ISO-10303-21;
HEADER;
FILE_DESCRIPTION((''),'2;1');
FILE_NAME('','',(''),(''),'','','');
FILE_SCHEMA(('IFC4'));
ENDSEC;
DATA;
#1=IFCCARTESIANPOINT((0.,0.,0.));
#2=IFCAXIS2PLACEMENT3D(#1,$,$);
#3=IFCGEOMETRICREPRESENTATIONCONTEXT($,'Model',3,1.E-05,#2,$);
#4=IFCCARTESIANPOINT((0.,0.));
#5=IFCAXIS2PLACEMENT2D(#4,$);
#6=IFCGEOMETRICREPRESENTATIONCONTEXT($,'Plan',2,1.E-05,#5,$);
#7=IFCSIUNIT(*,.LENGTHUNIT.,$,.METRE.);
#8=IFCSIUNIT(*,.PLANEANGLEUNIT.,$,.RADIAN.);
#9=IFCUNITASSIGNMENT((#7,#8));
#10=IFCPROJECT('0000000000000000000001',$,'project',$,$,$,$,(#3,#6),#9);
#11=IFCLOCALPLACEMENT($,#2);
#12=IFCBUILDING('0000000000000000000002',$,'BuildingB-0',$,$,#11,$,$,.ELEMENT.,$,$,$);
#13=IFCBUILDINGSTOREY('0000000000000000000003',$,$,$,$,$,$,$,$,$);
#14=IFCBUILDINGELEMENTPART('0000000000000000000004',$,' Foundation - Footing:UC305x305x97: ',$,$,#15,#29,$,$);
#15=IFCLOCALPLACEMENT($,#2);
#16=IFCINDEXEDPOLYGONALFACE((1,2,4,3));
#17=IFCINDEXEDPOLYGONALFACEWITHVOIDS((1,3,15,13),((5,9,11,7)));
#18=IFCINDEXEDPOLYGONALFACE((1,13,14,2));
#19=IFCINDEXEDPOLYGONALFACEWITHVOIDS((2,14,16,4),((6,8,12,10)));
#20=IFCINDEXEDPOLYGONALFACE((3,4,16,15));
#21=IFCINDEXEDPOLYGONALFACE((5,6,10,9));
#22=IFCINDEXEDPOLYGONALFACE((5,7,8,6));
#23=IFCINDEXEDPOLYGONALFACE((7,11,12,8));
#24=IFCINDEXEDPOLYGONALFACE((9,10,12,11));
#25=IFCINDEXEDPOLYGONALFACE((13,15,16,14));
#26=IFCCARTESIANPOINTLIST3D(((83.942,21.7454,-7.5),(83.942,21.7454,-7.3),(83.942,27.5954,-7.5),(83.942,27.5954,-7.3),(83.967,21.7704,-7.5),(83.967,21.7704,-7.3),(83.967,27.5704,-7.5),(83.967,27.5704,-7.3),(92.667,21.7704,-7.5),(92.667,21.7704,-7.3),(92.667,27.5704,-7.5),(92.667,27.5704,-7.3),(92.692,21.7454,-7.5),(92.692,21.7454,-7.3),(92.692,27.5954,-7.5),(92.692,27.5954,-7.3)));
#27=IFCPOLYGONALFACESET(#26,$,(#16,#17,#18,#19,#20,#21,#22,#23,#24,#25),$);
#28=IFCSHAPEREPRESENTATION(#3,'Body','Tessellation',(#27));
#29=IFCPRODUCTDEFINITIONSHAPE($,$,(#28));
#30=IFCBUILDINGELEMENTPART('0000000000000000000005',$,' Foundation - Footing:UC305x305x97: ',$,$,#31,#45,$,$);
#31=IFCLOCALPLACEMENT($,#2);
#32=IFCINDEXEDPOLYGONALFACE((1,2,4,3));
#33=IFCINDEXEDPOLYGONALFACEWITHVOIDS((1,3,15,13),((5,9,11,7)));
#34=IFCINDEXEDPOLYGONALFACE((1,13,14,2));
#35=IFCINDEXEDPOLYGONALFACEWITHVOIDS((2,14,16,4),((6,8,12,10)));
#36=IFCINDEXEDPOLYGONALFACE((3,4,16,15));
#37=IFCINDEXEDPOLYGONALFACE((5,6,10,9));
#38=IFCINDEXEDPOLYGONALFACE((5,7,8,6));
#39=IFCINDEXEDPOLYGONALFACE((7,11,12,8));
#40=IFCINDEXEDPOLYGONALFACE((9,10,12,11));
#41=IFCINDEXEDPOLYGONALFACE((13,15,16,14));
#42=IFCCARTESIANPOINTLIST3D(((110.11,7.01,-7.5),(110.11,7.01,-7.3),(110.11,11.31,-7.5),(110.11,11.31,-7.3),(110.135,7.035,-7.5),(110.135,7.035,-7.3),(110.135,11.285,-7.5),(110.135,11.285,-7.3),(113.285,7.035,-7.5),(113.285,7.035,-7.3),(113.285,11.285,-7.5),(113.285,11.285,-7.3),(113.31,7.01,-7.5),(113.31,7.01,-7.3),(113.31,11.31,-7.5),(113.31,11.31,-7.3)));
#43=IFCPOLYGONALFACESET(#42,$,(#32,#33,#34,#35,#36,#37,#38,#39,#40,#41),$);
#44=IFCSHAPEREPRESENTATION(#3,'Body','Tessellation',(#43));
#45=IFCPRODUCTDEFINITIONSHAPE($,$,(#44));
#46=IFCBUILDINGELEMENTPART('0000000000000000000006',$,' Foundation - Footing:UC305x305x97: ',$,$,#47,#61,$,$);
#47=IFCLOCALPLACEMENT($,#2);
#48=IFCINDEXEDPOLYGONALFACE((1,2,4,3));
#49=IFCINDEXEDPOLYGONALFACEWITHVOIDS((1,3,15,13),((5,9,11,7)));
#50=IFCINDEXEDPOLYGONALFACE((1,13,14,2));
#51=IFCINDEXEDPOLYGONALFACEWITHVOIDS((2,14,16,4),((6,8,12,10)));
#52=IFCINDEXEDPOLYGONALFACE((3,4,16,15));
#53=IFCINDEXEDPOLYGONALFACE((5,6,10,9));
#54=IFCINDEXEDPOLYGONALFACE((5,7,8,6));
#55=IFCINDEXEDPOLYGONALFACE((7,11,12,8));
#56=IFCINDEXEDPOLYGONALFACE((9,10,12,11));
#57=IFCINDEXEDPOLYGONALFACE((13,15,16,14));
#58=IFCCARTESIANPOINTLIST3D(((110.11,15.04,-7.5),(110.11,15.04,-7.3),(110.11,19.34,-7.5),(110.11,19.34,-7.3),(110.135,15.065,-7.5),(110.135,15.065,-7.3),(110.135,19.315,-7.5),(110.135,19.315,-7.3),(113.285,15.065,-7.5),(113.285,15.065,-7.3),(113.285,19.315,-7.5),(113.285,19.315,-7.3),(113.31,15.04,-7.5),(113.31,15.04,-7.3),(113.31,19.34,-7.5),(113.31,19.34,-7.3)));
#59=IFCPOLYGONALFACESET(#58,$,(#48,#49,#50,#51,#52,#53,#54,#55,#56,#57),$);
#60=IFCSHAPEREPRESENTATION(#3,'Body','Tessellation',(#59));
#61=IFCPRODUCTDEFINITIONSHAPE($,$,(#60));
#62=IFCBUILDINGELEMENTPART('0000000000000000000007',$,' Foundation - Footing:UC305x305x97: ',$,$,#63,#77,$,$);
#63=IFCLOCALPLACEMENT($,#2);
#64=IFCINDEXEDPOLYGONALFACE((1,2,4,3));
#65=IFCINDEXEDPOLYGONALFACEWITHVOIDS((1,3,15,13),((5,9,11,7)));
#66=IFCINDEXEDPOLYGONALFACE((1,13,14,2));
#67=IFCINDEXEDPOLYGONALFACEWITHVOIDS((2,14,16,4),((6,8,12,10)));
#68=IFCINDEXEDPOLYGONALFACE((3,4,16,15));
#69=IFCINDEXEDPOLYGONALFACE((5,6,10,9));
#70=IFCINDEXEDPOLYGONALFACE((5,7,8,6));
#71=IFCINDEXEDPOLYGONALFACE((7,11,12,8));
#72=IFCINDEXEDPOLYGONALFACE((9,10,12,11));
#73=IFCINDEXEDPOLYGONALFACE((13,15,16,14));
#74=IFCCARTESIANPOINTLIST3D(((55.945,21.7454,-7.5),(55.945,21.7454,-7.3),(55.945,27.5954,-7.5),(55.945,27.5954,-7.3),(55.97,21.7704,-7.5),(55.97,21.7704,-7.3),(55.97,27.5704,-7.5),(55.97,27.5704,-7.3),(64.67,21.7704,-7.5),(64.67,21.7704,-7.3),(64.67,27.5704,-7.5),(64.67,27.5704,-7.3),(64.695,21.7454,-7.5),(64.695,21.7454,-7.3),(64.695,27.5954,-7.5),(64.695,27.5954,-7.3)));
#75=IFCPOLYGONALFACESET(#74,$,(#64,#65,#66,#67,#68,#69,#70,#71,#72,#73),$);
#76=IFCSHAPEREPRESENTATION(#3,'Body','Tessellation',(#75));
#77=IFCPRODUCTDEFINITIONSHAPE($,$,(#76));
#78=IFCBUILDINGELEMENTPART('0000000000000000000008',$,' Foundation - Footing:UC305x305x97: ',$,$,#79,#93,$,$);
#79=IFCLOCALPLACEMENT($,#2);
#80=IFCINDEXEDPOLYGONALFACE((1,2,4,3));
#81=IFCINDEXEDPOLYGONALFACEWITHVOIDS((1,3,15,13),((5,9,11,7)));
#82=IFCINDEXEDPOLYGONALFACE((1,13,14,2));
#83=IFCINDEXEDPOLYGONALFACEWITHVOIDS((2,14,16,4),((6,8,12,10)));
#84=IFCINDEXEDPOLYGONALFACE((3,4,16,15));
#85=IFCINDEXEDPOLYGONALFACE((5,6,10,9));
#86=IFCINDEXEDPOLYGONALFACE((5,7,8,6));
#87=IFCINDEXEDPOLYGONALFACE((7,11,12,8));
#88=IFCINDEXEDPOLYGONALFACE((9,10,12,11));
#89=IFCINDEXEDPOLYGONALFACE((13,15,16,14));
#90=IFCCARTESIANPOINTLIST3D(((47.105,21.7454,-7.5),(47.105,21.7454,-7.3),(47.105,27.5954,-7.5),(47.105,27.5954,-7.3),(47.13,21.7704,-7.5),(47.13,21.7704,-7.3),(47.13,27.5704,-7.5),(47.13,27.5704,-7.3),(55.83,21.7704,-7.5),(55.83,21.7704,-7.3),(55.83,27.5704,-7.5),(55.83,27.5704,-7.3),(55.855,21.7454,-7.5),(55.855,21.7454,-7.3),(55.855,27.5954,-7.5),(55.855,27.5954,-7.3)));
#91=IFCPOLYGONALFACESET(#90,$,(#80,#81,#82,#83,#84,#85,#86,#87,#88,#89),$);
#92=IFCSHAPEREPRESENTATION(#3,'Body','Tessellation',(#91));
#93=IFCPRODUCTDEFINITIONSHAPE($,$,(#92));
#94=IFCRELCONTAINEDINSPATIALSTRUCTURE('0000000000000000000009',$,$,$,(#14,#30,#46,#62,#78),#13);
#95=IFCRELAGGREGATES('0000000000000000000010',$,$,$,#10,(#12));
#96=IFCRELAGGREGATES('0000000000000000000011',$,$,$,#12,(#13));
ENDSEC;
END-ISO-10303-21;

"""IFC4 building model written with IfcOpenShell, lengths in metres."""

from ifc_helpers import new_model, si_unit, origin, origin_2d, place, context, project, spatial, polyline, outline, extrude, element, save


model = new_model("IFC4")

# Units and contexts
model_context = context("Model", 3, precision=1e-05, world=origin())
plan_context = context("Plan", 2, precision=1e-05, world=origin_2d())
ifc_project = project(units=[si_unit("LENGTHUNIT", "METRE"), si_unit("PLANEANGLEUNIT", "RADIAN")], contexts=[model_context, plan_context])

# Building, storey
building_placement = place(None, origin())
building = spatial("IfcBuilding", under=ifc_project, at=building_placement, Name="BuildingB-0", CompositionType="ELEMENT")
storey = spatial("IfcBuildingStorey", under=building)

# Building element parts, openings
building_element_part_1 = element("IfcBuildingElementPart", 1, inside=storey, Name=" Foundation - Footing:UC305x305x97: ", context=model_context, shape_type="SweptSolid", body=[
    extrude(outline(polyline([(83.942, 21.7454, -7.5), (92.692, 21.7454, -7.5), (92.692, 27.5954, -7.5), (83.942, 27.5954, -7.5), (83.942, 21.7454, -7.5)])), None, (0.0, 0.0, 1.0), 0.2),
])
element("IfcOpeningElement", 2, inside=storey, cuts=building_element_part_1, context=model_context, shape_type="SweptSolid", body=[
    extrude(outline(polyline([(83.967, 21.7704, -7.5), (92.667, 21.7704, -7.5), (92.667, 27.5704, -7.5), (83.967, 27.5704, -7.5), (83.967, 21.7704, -7.5)])), None, (0.0, 0.0, 1.0), 0.2),
])
building_element_part_2 = element("IfcBuildingElementPart", 3, inside=storey, Name=" Foundation - Footing:UC305x305x97: ", context=model_context, shape_type="SweptSolid", body=[
    extrude(outline(polyline([(110.11, 11.31, -7.5), (113.31, 11.31, -7.5), (113.31, 7.01, -7.5), (110.11, 7.01, -7.5), (110.11, 11.31, -7.5)])), None, (0.0, 0.0, 1.0), 0.2),
])
element("IfcOpeningElement", 4, inside=storey, cuts=building_element_part_2, context=model_context, shape_type="SweptSolid", body=[
    extrude(outline(polyline([(110.135, 11.285, -7.5), (113.285, 11.285, -7.5), (113.285, 7.035, -7.5), (110.135, 7.035, -7.5), (110.135, 11.285, -7.5)])), None, (0.0, 0.0, 1.0), 0.2),
])
building_element_part_3 = element("IfcBuildingElementPart", 5, inside=storey, Name=" Foundation - Footing:UC305x305x97: ", context=model_context, shape_type="SweptSolid", body=[
    extrude(outline(polyline([(110.11, 19.34, -7.5), (113.31, 19.34, -7.5), (113.31, 15.04, -7.5), (110.11, 15.04, -7.5), (110.11, 19.34, -7.5)])), None, (0.0, 0.0, 1.0), 0.2),
])
element("IfcOpeningElement", 6, inside=storey, cuts=building_element_part_3, context=model_context, shape_type="SweptSolid", body=[
    extrude(outline(polyline([(110.135, 19.315, -7.5), (113.285, 19.315, -7.5), (113.285, 15.065, -7.5), (110.135, 15.065, -7.5), (110.135, 19.315, -7.5)])), None, (0.0, 0.0, 1.0), 0.2),
])
building_element_part_4 = element("IfcBuildingElementPart", 7, inside=storey, Name=" Foundation - Footing:UC305x305x97: ", context=model_context, shape_type="SweptSolid", body=[
    extrude(outline(polyline([(55.945, 27.5954, -7.5), (64.695, 27.5954, -7.5), (64.695, 21.7454, -7.5), (55.945, 21.7454, -7.5), (55.945, 27.5954, -7.5)])), None, (0.0, 0.0, 1.0), 0.2),
])
element("IfcOpeningElement", 8, inside=storey, cuts=building_element_part_4, context=model_context, shape_type="SweptSolid", body=[
    extrude(outline(polyline([(55.97, 27.5704, -7.5), (64.67, 27.5704, -7.5), (64.67, 21.7704, -7.5), (55.97, 21.7704, -7.5), (55.97, 27.5704, -7.5)])), None, (0.0, 0.0, 1.0), 0.2),
])
building_element_part_5 = element("IfcBuildingElementPart", 9, inside=storey, Name=" Foundation - Footing:UC305x305x97: ", context=model_context, shape_type="SweptSolid", body=[
    extrude(outline(polyline([(47.105, 21.7454, -7.5), (55.855, 21.7454, -7.5), (55.855, 27.5954, -7.5), (47.105, 27.5954, -7.5), (47.105, 21.7454, -7.5)])), None, (0.0, 0.0, 1.0), 0.2),
])
element("IfcOpeningElement", 10, inside=storey, cuts=building_element_part_5, context=model_context, shape_type="SweptSolid", body=[
    extrude(outline(polyline([(47.13, 21.7704, -7.5), (55.83, 21.7704, -7.5), (55.83, 27.5704, -7.5), (47.13, 27.5704, -7.5), (47.13, 21.7704, -7.5)])), None, (0.0, 0.0, 1.0), 0.2),
])

save(model, "model.ifc")
